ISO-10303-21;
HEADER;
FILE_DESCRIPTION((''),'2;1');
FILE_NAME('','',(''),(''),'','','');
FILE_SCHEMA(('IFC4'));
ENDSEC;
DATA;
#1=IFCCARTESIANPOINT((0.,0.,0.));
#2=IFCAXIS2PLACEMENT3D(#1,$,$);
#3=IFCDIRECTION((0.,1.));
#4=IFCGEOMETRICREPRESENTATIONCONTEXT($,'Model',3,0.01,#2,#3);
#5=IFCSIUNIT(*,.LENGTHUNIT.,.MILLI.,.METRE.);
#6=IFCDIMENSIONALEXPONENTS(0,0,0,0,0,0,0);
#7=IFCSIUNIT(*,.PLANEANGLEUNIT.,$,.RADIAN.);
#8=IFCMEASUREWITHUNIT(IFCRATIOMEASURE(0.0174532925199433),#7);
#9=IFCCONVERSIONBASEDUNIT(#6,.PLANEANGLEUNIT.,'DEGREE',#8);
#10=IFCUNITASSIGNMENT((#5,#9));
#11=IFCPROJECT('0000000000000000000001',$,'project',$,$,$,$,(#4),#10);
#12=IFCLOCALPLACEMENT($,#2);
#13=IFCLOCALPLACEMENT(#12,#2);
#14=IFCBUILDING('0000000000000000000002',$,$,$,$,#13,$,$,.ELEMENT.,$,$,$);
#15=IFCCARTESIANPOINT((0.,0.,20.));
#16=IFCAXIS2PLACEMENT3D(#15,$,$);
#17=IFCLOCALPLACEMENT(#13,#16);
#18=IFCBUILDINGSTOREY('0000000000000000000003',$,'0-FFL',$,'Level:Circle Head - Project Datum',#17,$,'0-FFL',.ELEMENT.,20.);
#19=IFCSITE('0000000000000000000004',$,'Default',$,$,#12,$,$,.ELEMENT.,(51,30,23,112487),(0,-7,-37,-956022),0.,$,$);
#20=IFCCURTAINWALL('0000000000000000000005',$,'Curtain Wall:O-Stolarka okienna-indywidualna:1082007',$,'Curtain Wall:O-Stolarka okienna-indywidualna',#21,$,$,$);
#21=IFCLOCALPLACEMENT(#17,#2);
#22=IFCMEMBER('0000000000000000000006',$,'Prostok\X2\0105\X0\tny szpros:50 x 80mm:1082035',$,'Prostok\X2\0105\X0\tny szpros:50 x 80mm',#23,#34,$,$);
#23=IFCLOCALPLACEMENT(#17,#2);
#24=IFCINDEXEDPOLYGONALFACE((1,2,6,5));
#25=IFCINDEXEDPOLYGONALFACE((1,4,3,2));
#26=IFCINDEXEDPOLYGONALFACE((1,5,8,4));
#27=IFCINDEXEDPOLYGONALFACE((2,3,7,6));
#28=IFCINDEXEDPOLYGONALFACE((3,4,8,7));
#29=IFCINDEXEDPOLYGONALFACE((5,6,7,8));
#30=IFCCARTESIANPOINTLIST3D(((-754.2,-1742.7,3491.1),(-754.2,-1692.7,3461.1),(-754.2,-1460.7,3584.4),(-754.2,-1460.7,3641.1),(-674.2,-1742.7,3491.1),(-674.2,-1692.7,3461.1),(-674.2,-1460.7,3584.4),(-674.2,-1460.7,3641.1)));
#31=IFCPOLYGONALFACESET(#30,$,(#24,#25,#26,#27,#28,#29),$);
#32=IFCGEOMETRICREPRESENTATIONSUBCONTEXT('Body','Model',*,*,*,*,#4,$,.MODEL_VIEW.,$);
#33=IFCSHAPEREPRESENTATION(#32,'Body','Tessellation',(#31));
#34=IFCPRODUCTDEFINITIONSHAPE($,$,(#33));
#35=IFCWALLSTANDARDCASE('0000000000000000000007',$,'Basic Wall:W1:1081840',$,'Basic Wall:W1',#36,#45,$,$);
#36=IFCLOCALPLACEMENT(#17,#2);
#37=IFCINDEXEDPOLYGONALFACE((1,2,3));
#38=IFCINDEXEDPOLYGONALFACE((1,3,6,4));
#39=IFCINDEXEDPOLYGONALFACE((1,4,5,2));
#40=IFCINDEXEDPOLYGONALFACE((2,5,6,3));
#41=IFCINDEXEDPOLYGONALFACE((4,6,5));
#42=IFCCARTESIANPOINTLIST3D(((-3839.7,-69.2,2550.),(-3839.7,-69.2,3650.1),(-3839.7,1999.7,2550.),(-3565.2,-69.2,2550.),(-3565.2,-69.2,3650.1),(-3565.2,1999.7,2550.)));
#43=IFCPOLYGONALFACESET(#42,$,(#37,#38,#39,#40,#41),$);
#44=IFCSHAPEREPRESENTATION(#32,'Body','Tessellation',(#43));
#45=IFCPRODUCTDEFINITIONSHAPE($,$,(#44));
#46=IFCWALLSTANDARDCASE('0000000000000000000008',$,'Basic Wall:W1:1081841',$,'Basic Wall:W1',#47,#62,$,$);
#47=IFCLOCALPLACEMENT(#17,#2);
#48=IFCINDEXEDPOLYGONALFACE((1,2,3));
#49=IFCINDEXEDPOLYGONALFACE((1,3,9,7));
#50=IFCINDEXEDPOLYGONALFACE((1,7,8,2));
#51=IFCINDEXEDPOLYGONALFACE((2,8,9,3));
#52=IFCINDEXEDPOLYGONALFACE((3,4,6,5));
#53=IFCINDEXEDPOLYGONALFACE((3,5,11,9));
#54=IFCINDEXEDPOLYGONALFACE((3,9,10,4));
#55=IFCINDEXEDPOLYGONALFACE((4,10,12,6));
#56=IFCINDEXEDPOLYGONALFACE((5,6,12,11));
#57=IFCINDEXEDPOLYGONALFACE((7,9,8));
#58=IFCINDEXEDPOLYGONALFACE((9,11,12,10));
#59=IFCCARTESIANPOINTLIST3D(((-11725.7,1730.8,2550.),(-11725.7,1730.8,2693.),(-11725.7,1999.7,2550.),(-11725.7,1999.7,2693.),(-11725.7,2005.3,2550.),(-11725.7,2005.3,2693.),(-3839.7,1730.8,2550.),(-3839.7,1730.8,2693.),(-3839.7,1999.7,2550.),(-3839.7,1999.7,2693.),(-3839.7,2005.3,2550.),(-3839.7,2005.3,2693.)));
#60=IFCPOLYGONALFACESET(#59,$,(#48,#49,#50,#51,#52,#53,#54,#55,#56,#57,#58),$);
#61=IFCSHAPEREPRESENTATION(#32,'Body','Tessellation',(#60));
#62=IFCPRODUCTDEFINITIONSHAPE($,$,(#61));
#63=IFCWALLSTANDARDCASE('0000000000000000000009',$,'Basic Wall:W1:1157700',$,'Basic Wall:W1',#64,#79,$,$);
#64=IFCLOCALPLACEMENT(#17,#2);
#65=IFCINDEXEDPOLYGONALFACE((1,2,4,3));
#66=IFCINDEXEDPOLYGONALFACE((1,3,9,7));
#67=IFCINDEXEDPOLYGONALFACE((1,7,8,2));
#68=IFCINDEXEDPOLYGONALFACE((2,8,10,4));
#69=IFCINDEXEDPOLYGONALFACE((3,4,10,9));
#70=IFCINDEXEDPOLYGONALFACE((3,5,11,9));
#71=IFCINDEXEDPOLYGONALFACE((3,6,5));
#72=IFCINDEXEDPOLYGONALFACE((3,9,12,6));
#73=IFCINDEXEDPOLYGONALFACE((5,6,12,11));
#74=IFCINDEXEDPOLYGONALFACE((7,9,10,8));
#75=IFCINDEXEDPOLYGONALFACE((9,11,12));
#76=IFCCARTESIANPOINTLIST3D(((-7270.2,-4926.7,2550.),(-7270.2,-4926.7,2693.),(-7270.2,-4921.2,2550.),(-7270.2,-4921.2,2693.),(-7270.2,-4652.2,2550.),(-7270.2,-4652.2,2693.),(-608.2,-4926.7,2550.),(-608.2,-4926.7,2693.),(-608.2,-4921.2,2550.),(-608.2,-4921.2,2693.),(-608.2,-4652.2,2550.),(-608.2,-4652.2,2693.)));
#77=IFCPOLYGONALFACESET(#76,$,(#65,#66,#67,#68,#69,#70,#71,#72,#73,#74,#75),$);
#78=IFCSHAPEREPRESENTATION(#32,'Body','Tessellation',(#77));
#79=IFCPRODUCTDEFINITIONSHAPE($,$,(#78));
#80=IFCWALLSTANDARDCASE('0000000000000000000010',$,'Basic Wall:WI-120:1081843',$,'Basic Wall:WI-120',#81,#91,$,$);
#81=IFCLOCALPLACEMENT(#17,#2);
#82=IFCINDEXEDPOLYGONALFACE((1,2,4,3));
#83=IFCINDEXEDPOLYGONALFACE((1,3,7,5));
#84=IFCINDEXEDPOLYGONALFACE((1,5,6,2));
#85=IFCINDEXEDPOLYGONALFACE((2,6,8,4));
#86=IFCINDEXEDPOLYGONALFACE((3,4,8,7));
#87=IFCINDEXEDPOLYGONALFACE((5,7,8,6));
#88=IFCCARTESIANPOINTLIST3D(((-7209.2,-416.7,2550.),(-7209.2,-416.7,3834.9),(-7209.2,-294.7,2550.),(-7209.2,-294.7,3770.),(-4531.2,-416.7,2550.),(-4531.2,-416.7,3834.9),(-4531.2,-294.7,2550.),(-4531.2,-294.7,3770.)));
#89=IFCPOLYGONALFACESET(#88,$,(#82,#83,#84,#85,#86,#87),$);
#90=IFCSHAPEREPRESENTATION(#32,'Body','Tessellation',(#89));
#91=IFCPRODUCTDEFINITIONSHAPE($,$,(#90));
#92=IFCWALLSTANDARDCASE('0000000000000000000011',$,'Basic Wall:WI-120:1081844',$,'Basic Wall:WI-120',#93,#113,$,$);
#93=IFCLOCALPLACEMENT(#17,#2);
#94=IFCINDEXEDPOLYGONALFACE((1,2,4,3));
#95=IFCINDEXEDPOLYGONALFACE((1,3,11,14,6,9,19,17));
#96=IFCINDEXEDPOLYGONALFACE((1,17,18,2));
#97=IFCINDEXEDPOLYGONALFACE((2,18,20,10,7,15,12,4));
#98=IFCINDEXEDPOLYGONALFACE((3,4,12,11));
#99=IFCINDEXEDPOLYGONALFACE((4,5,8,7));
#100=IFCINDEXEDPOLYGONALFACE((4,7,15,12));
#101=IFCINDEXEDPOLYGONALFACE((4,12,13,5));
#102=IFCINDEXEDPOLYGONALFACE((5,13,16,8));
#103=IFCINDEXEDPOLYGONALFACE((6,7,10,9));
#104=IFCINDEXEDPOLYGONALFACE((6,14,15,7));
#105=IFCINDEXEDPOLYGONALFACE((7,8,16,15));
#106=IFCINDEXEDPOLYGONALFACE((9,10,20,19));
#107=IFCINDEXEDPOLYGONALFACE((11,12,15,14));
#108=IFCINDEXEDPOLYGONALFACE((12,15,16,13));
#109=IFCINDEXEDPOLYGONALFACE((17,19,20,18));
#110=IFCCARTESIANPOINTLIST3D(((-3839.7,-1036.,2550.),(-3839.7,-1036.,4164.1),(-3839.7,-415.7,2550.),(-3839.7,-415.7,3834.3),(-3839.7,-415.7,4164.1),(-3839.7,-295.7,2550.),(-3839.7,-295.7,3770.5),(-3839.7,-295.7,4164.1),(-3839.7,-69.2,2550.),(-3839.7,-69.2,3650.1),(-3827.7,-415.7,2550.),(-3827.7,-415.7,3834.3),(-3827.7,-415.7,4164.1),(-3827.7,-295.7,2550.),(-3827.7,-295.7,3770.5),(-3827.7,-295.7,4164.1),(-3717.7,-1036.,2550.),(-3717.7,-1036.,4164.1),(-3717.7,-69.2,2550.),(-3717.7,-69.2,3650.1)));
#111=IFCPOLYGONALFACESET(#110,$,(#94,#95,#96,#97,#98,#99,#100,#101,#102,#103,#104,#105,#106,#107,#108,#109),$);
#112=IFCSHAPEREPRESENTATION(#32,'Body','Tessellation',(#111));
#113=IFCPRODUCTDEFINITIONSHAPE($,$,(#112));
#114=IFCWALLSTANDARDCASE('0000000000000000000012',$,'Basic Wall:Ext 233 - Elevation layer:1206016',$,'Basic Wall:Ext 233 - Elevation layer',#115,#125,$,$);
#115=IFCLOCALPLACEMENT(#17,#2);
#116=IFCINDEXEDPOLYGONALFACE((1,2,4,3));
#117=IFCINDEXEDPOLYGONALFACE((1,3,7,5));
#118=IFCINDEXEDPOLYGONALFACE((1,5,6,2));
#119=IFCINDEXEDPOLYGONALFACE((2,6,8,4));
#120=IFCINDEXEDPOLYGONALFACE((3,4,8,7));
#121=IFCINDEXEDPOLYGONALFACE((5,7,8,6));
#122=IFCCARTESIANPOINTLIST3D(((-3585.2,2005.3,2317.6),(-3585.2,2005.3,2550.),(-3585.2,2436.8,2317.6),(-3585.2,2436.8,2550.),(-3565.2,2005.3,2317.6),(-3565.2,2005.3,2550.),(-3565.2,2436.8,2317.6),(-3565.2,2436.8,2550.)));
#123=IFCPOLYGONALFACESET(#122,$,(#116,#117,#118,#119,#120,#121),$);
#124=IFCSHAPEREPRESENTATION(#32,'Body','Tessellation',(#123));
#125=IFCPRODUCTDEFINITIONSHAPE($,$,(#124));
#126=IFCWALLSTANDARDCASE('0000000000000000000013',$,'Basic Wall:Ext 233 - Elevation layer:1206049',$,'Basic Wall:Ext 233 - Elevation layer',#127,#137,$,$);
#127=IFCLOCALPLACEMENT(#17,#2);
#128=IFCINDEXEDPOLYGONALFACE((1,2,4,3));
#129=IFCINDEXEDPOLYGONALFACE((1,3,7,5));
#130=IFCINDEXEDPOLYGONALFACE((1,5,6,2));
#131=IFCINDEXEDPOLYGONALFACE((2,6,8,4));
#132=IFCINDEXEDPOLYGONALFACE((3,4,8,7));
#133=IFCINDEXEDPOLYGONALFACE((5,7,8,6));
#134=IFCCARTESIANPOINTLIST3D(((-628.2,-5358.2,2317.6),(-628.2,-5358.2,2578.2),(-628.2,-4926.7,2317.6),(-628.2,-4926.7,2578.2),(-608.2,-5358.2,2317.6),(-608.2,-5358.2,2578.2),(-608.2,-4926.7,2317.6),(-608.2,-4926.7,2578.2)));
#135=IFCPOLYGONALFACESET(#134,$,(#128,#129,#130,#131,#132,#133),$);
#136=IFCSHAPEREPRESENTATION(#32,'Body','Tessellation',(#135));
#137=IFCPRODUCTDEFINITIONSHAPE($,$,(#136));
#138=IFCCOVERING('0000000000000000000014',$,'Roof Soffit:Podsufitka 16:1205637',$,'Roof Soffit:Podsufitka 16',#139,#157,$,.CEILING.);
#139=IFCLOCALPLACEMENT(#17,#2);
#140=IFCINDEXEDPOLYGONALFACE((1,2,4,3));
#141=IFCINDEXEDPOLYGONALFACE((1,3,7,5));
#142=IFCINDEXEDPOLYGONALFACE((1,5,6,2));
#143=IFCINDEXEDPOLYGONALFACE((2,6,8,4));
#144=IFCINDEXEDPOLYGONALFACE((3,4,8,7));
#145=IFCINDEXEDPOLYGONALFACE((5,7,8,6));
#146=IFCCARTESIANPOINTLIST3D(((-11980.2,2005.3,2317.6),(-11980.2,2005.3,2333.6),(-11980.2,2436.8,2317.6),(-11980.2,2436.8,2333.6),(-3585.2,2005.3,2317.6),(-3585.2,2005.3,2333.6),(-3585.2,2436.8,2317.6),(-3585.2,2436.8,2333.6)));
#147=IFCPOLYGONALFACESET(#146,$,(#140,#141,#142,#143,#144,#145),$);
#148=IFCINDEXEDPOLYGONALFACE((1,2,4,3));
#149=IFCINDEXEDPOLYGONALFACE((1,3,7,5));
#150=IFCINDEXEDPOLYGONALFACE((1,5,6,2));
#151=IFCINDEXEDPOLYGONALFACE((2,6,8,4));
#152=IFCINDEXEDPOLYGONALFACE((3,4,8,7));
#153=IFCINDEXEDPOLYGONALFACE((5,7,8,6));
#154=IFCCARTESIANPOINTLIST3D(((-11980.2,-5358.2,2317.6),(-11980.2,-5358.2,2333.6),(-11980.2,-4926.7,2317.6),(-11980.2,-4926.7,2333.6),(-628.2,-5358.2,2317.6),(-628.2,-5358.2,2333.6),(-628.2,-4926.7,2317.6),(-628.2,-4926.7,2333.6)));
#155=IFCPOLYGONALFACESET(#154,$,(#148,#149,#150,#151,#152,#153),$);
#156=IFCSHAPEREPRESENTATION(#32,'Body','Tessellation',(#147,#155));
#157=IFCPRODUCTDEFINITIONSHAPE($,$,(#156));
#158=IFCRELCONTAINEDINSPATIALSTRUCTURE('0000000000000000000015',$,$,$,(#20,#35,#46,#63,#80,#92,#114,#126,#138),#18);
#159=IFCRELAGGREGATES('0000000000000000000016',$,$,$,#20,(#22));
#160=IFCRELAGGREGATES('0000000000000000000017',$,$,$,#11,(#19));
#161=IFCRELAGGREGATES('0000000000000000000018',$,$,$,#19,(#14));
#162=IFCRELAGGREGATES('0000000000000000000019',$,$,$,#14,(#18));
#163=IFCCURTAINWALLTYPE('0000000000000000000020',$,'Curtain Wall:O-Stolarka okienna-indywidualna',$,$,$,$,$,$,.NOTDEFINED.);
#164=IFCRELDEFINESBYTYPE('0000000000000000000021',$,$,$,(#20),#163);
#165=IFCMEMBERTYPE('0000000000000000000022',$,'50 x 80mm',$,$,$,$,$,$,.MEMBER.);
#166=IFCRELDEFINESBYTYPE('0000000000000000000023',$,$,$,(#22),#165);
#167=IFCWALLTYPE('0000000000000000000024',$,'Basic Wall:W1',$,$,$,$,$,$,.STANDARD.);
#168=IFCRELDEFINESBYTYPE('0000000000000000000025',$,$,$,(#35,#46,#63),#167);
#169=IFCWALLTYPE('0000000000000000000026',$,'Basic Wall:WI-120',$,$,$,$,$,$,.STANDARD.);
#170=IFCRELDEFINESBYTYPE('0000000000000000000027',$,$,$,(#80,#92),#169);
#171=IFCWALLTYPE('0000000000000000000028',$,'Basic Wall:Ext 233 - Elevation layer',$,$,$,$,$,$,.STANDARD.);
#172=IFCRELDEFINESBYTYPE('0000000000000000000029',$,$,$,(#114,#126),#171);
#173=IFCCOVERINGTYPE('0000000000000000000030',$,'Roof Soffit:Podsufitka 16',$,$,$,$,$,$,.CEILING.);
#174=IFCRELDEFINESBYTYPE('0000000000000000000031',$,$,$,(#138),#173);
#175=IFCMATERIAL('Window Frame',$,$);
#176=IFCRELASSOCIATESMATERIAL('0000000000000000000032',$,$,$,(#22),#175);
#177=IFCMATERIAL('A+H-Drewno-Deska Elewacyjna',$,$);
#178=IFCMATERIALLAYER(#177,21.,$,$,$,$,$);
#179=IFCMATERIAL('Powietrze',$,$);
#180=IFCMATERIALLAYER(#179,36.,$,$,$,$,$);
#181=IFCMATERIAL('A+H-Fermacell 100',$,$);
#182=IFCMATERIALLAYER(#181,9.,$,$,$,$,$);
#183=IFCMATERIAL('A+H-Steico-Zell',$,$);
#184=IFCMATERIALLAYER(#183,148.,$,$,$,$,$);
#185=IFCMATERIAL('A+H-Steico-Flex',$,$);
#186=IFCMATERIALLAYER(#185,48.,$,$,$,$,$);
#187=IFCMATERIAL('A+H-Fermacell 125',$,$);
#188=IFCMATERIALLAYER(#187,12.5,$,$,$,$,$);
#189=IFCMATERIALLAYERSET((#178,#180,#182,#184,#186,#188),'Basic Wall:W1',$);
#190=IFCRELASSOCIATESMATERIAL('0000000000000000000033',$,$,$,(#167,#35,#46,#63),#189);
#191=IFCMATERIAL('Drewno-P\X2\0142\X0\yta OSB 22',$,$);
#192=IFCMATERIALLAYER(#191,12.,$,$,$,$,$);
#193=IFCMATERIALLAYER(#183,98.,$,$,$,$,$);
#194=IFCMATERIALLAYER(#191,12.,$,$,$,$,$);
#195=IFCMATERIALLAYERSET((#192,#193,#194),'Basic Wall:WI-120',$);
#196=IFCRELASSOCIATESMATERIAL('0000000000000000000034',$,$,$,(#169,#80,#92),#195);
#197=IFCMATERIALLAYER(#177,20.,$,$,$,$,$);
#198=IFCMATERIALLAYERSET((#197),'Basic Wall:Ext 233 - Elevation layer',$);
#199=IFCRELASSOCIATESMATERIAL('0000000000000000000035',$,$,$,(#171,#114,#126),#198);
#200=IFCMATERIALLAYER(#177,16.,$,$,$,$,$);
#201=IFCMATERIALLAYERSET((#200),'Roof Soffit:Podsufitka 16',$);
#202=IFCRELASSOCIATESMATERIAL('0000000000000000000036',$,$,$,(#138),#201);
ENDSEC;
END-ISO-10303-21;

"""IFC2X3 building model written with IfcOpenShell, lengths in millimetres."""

from ifc_helpers import new_model, entity, si_unit, converted_unit, direction, frame, frame_2d, origin, origin_2d_with_axis, place, context, subcontext, project, spatial, polyline, rectangle, extrude, clip, halfspace, bounded_halfspace, source, transform, mapped, material, layer, layer_set, layer_usage, type_object, type_shapes, element, aggregate, save


model = new_model("IFC2X3")

# Units and contexts
model_context = context("Model", 3, precision=0.01, world=origin(), true_north=direction((0.0, 1.0)))
body_context = subcontext(model_context, "Body", "Model", "MODEL_VIEW")
ifc_project = project(units=[si_unit("LENGTHUNIT", "METRE", prefix="MILLI"), converted_unit("PLANEANGLEUNIT", "DEGREE", entity("IfcRatioMeasure", 0.0174532925199433), si_unit("PLANEANGLEUNIT", "RADIAN"), dimensions=[0, 0, 0, 0, 0, 0, 0])], contexts=[model_context])

# Site, building, storey
site_placement = place(None, origin())
site = spatial("IfcSite", under=ifc_project, at=site_placement, Name="Default", CompositionType="ELEMENT", RefLatitude=(51, 30, 23, 112487), RefLongitude=(0, -7, -37, -956022), RefElevation=0.0)
building_placement = place(site_placement, origin())
building = spatial("IfcBuilding", under=site, at=building_placement, CompositionType="ELEMENT")
storey_placement = place(building_placement, frame((0.0, 0.0, 20.0)))
storey = spatial("IfcBuildingStorey", under=building, at=storey_placement, Name="0-FFL", ObjectType="Level:Circle Head - Project Datum", LongName="0-FFL", CompositionType="ELEMENT", Elevation=20.0)

# Curtain wall
curtain_wall_type = type_object("IfcCurtainWallType", Name="Curtain Wall:O-Stolarka okienna-indywidualna", PredefinedType="NOTDEFINED")
ifc_material_1 = material(Name="Window Frame")
curtain_wall_1_placement = place(storey_placement, frame((0.0, 0.0, -20.0)))
curtain_wall_1 = element("IfcCurtainWall", 1, at=curtain_wall_1_placement, inside=storey, type_object=curtain_wall_type, Name="Curtain Wall:O-Stolarka okienna-indywidualna:1082007", ObjectType="Curtain Wall:O-Stolarka okienna-indywidualna")

# Member
member_type_1 = type_object("IfcMemberType", Name="50 x 80mm", PredefinedType="MEMBER")
shared_shape_1 = source(origin(), body_context, "Body", "Clipping", [
    clip(clip(extrude(rectangle(XDim=80.0, YDim=50.0, at=origin_2d_with_axis()), frame((-25.0, 0.0, -319.4), z_axis=(0.0, 0.0, 1.0), x_axis=(0.0, -1.0, 0.0)), (0.0, 0.0, 1.0), 319.4), halfspace(frame((0.0, -304.8, -319.4), z_axis=(-0.469471, 0.0, -0.882948), x_axis=(-0.882948, 0.0, 0.469471)), False)), halfspace(frame((0.0, -304.8, 0.0), z_axis=(-0.515038, 0.0, 0.857167), x_axis=(-0.857167, 0.0, -0.515038)), False)),
])
type_shapes(member_type_1, [shared_shape_1])
member_1_placement = place(storey_placement, frame((-714.2, -1742.7, 3491.1), z_axis=(0.0, -0.882948, -0.469472), x_axis=(0.0, -0.469472, 0.882948)))
member_1 = element("IfcMember", 2, at=member_1_placement, type_object=member_type_1, material=ifc_material_1, Name="Prostokątny szpros:50 x 80mm:1082035", ObjectType="Prostokątny szpros:50 x 80mm", context=body_context, shape_type="MappedRepresentation", body=[
    mapped(shared_shape_1, transform((0.0, 0.0, 0.0), scale=1.0)),
])

aggregate(curtain_wall_1, [member_1])

# Shared definitions
ifc_material_2 = material(Name="A+H-Drewno-Deska Elewacyjna")
ifc_layer_1 = layer(ifc_material_2, 21.0)
ifc_material_3 = material(Name="Powietrze")
ifc_layer_2 = layer(ifc_material_3, 36.0)
ifc_material_4 = material(Name="A+H-Fermacell 100")
ifc_layer_3 = layer(ifc_material_4, 9.0)
ifc_material_5 = material(Name="A+H-Steico-Zell")
ifc_layer_4 = layer(ifc_material_5, 148.0)
ifc_material_6 = material(Name="A+H-Steico-Flex")
ifc_layer_5 = layer(ifc_material_6, 48.0)
ifc_material_7 = material(Name="A+H-Fermacell 125")
ifc_layer_6 = layer(ifc_material_7, 12.5)
ifc_layer_set_1 = layer_set([ifc_layer_1, ifc_layer_2, ifc_layer_3, ifc_layer_4, ifc_layer_5, ifc_layer_6], Name="Basic Wall:W1")
wall_type_1 = type_object("IfcWallType", Name="Basic Wall:W1", PredefinedType="STANDARD", material=ifc_layer_set_1)

# Walls
ifc_layer_usage_1 = layer_usage(ifc_layer_set_1, "AXIS2", "POSITIVE", -137.2)
wall_1_placement = place(storey_placement, frame((-3702.4, -69.2, 2550.0), z_axis=(0.0, 0.0, 1.0), x_axis=(0.0, 1.0, 0.0)))
element("IfcWallStandardCase", 3, at=wall_1_placement, inside=storey, type_object=wall_type_1, material=ifc_layer_usage_1, Name="Basic Wall:W1:1081840", ObjectType="Basic Wall:W1", context=body_context, shape_type="Clipping", body=[
    clip(extrude(rectangle(XDim=2069.0, YDim=274.5, at=frame_2d((1034.5, 0.0), x_axis=(-1.0, 0.0))), origin(), (0.0, 0.0, 1.0), 1100.1), bounded_halfspace(frame((0.0, -137.2, 1100.1), z_axis=(0.469472, 0.0, 0.882948), x_axis=(0.0, 1.0, 0.0)), False, frame((0.0, -137.2, 1100.1)), polyline([(0.0, 0.0), (274.5, 0.0), (2069.0, 0.0), (2069.0, 274.5), (1800.0, 274.5), (0.0, 274.5), (0.0, 0.0)]))),
])
ifc_layer_usage_2 = layer_usage(ifc_layer_set_1, "AXIS2", "POSITIVE", -137.2)
wall_2_placement = place(storey_placement, frame((-3839.7, 1868.0, 2550.0), z_axis=(0.0, 0.0, 1.0), x_axis=(-1.0, 0.0, 0.0)))
element("IfcWallStandardCase", 4, at=wall_2_placement, inside=storey, type_object=wall_type_1, material=ifc_layer_usage_2, Name="Basic Wall:W1:1081841", ObjectType="Basic Wall:W1", context=body_context, shape_type="Clipping", body=[
    clip(extrude(rectangle(XDim=7886.0, YDim=274.5, at=frame_2d((3943.0, 0.0), x_axis=(-1.0, 0.0))), origin(), (0.0, 0.0, 1.0), 143.0), bounded_halfspace(frame((7886.0, 137.2, 143.0), z_axis=(0.0, -0.469472, 0.882948), x_axis=(1.0, 0.0, 0.0)), False, frame((7886.0, 137.2, 143.0)), polyline([(0.0, 0.0), (-7886.0, 0.0), (-7886.0, -269.0), (0.0, -269.0), (0.0, 0.0)]))),
])
ifc_layer_usage_3 = layer_usage(ifc_layer_set_1, "AXIS2", "POSITIVE", -137.2)
wall_3_placement = place(storey_placement, frame((-7270.2, -4789.5, 2550.0)))
element("IfcWallStandardCase", 5, at=wall_3_placement, inside=storey, type_object=wall_type_1, material=ifc_layer_usage_3, Name="Basic Wall:W1:1157700", ObjectType="Basic Wall:W1", context=body_context, shape_type="Clipping", body=[
    clip(extrude(rectangle(XDim=6662.0, YDim=274.5, at=frame_2d((3331.0, 0.0), x_axis=(-1.0, 0.0))), origin(), (0.0, 0.0, 1.0), 143.0), bounded_halfspace(frame((6662.0, 137.2, 143.0), z_axis=(0.0, -0.469472, 0.882948), x_axis=(1.0, 0.0, 0.0)), False, frame((6662.0, 137.2, 143.0)), polyline([(0.0, 0.0), (-274.5, 0.0), (-6601.0, 0.0), (-6662.0, 0.0), (-6662.0, -269.0), (0.0, -269.0), (0.0, 0.0)]))),
])

# Shared definitions
ifc_material_8 = material(Name="Drewno-Płyta OSB 22")
ifc_layer_7 = layer(ifc_material_8, 12.0)
ifc_layer_8 = layer(ifc_material_5, 98.0)
ifc_layer_9 = layer(ifc_material_8, 12.0)
ifc_layer_set_2 = layer_set([ifc_layer_7, ifc_layer_8, ifc_layer_9], Name="Basic Wall:WI-120")
wall_type_2 = type_object("IfcWallType", Name="Basic Wall:WI-120", PredefinedType="STANDARD", material=ifc_layer_set_2)

# Walls
ifc_layer_usage_4 = layer_usage(ifc_layer_set_2, "AXIS2", "NEGATIVE", 61.0)
wall_4_placement = place(storey_placement, frame((-7209.2, -355.7, 2550.0)))
element("IfcWallStandardCase", 6, at=wall_4_placement, inside=storey, type_object=wall_type_2, material=ifc_layer_usage_4, Name="Basic Wall:WI-120:1081843", ObjectType="Basic Wall:WI-120", context=body_context, shape_type="Clipping", body=[
    clip(extrude(rectangle(XDim=2678.0, YDim=122.0, at=frame_2d((1339.0, 0.0), x_axis=(-1.0, 0.0))), origin(), (0.0, 0.0, 1.0), 1284.9), bounded_halfspace(frame((0.0, -61.0, 1284.9), z_axis=(0.0, 0.469472, 0.882948), x_axis=(-1.0, 0.0, 0.0)), False, frame((0.0, -61.0, 1284.9)), polyline([(0.0, 0.0), (2678.0, 0.0), (2678.0, 122.0), (0.0, 122.0), (0.0, 0.0)]))),
])
ifc_layer_usage_5 = layer_usage(ifc_layer_set_2, "AXIS2", "NEGATIVE", 61.0)
wall_5_placement = place(storey_placement, frame((-3778.7, -1036.0, 2550.0), z_axis=(0.0, 0.0, 1.0), x_axis=(0.0, 1.0, 0.0)))
element("IfcWallStandardCase", 7, at=wall_5_placement, inside=storey, type_object=wall_type_2, material=ifc_layer_usage_5, Name="Basic Wall:WI-120:1081844", ObjectType="Basic Wall:WI-120", context=body_context, shape_type="Clipping", body=[
    clip(clip(extrude(rectangle(XDim=966.8, YDim=122.0, at=frame_2d((483.4, 0.0), x_axis=(-1.0, 0.0))), origin(), (0.0, 0.0, 1.0), 1614.1), bounded_halfspace(frame((0.0, -61.0, 1614.1), z_axis=(0.469472, 0.0, 0.882948), x_axis=(0.0, 1.0, 0.0)), False, frame((0.0, -61.0, 1614.1)), polyline([(0.0, 0.0), (966.8, 0.0), (966.8, 122.0), (740.3, 122.0), (740.3, 110.0), (620.3, 110.0), (620.3, 122.0), (0.0, 122.0), (0.0, 0.0)]))), bounded_halfspace(frame((620.3, 49.0, 0.0), z_axis=(0.0, -1.0, 0.0), x_axis=(1.0, 0.0, 0.0)), True, frame((620.3, 49.0, 0.0), z_axis=(0.0, -1.0, 0.0), x_axis=(1.0, 0.0, 0.0)), polyline([(0.0, 0.0), (120.0, 0.0), (120.0, 1220.5), (0.0, 1284.3), (0.0, 0.0)]))),
])
ifc_layer_10 = layer(ifc_material_2, 20.0)
ifc_layer_set_3 = layer_set([ifc_layer_10], Name="Basic Wall:Ext 233 - Elevation layer")
ifc_layer_usage_6 = layer_usage(ifc_layer_set_3, "AXIS2", "NEGATIVE", 10.0)
wall_type_3 = type_object("IfcWallType", Name="Basic Wall:Ext 233 - Elevation layer", PredefinedType="STANDARD", material=ifc_layer_set_3)
wall_6_placement = place(storey_placement, frame((-3575.2, 2436.8, 2317.6), z_axis=(0.0, 0.0, 1.0), x_axis=(0.0, -1.0, 0.0)))
element("IfcWallStandardCase", 8, at=wall_6_placement, inside=storey, type_object=wall_type_3, material=ifc_layer_usage_6, Name="Basic Wall:Ext 233 - Elevation layer:1206016", ObjectType="Basic Wall:Ext 233 - Elevation layer", context=body_context, shape_type="SweptSolid", body=[
    extrude(rectangle(XDim=431.5, YDim=20.0, at=frame_2d((215.7, 0.0), x_axis=(-1.0, 0.0))), origin(), (0.0, 0.0, 1.0), 232.4),
])
ifc_layer_usage_7 = layer_usage(ifc_layer_set_3, "AXIS2", "NEGATIVE", 10.0)
wall_7_placement = place(storey_placement, frame((-618.2, -4926.7, 2317.6), z_axis=(0.0, 0.0, 1.0), x_axis=(0.0, -1.0, 0.0)))
element("IfcWallStandardCase", 9, at=wall_7_placement, inside=storey, type_object=wall_type_3, material=ifc_layer_usage_7, Name="Basic Wall:Ext 233 - Elevation layer:1206049", ObjectType="Basic Wall:Ext 233 - Elevation layer", context=body_context, shape_type="SweptSolid", body=[
    extrude(rectangle(XDim=431.5, YDim=20.0, at=frame_2d((215.7, 0.0), x_axis=(-1.0, 0.0))), origin(), (0.0, 0.0, 1.0), 260.6),
])

# Covering
ifc_layer_11 = layer(ifc_material_2, 16.0)
ifc_layer_set_4 = layer_set([ifc_layer_11], Name="Roof Soffit:Podsufitka 16")
ifc_layer_usage_8 = layer_usage(ifc_layer_set_4, "AXIS3", "POSITIVE", 0.0)
covering_type = type_object("IfcCoveringType", Name="Roof Soffit:Podsufitka 16", PredefinedType="CEILING")
covering_placement = place(storey_placement, origin())
element("IfcCovering", 10, at=covering_placement, inside=storey, type_object=covering_type, material=ifc_layer_usage_8, Name="Roof Soffit:Podsufitka 16:1205637", ObjectType="Roof Soffit:Podsufitka 16", PredefinedType="CEILING", context=body_context, shape_type="SweptSolid", body=[
    extrude(rectangle(XDim=8395.0, YDim=431.5, at=frame_2d((0.0, 0.0), x_axis=(1.0, 0.0))), frame((-7782.7, 2221.0, 2317.6)), (0.0, 0.0, 1.0), 16.0),
    extrude(rectangle(XDim=11352.0, YDim=431.5, at=frame_2d((0.0, 0.0), x_axis=(1.0, 0.0))), frame((-6304.2, -5142.5, 2317.6)), (0.0, 0.0, 1.0), 16.0),
])

save(model, "model.ifc")
